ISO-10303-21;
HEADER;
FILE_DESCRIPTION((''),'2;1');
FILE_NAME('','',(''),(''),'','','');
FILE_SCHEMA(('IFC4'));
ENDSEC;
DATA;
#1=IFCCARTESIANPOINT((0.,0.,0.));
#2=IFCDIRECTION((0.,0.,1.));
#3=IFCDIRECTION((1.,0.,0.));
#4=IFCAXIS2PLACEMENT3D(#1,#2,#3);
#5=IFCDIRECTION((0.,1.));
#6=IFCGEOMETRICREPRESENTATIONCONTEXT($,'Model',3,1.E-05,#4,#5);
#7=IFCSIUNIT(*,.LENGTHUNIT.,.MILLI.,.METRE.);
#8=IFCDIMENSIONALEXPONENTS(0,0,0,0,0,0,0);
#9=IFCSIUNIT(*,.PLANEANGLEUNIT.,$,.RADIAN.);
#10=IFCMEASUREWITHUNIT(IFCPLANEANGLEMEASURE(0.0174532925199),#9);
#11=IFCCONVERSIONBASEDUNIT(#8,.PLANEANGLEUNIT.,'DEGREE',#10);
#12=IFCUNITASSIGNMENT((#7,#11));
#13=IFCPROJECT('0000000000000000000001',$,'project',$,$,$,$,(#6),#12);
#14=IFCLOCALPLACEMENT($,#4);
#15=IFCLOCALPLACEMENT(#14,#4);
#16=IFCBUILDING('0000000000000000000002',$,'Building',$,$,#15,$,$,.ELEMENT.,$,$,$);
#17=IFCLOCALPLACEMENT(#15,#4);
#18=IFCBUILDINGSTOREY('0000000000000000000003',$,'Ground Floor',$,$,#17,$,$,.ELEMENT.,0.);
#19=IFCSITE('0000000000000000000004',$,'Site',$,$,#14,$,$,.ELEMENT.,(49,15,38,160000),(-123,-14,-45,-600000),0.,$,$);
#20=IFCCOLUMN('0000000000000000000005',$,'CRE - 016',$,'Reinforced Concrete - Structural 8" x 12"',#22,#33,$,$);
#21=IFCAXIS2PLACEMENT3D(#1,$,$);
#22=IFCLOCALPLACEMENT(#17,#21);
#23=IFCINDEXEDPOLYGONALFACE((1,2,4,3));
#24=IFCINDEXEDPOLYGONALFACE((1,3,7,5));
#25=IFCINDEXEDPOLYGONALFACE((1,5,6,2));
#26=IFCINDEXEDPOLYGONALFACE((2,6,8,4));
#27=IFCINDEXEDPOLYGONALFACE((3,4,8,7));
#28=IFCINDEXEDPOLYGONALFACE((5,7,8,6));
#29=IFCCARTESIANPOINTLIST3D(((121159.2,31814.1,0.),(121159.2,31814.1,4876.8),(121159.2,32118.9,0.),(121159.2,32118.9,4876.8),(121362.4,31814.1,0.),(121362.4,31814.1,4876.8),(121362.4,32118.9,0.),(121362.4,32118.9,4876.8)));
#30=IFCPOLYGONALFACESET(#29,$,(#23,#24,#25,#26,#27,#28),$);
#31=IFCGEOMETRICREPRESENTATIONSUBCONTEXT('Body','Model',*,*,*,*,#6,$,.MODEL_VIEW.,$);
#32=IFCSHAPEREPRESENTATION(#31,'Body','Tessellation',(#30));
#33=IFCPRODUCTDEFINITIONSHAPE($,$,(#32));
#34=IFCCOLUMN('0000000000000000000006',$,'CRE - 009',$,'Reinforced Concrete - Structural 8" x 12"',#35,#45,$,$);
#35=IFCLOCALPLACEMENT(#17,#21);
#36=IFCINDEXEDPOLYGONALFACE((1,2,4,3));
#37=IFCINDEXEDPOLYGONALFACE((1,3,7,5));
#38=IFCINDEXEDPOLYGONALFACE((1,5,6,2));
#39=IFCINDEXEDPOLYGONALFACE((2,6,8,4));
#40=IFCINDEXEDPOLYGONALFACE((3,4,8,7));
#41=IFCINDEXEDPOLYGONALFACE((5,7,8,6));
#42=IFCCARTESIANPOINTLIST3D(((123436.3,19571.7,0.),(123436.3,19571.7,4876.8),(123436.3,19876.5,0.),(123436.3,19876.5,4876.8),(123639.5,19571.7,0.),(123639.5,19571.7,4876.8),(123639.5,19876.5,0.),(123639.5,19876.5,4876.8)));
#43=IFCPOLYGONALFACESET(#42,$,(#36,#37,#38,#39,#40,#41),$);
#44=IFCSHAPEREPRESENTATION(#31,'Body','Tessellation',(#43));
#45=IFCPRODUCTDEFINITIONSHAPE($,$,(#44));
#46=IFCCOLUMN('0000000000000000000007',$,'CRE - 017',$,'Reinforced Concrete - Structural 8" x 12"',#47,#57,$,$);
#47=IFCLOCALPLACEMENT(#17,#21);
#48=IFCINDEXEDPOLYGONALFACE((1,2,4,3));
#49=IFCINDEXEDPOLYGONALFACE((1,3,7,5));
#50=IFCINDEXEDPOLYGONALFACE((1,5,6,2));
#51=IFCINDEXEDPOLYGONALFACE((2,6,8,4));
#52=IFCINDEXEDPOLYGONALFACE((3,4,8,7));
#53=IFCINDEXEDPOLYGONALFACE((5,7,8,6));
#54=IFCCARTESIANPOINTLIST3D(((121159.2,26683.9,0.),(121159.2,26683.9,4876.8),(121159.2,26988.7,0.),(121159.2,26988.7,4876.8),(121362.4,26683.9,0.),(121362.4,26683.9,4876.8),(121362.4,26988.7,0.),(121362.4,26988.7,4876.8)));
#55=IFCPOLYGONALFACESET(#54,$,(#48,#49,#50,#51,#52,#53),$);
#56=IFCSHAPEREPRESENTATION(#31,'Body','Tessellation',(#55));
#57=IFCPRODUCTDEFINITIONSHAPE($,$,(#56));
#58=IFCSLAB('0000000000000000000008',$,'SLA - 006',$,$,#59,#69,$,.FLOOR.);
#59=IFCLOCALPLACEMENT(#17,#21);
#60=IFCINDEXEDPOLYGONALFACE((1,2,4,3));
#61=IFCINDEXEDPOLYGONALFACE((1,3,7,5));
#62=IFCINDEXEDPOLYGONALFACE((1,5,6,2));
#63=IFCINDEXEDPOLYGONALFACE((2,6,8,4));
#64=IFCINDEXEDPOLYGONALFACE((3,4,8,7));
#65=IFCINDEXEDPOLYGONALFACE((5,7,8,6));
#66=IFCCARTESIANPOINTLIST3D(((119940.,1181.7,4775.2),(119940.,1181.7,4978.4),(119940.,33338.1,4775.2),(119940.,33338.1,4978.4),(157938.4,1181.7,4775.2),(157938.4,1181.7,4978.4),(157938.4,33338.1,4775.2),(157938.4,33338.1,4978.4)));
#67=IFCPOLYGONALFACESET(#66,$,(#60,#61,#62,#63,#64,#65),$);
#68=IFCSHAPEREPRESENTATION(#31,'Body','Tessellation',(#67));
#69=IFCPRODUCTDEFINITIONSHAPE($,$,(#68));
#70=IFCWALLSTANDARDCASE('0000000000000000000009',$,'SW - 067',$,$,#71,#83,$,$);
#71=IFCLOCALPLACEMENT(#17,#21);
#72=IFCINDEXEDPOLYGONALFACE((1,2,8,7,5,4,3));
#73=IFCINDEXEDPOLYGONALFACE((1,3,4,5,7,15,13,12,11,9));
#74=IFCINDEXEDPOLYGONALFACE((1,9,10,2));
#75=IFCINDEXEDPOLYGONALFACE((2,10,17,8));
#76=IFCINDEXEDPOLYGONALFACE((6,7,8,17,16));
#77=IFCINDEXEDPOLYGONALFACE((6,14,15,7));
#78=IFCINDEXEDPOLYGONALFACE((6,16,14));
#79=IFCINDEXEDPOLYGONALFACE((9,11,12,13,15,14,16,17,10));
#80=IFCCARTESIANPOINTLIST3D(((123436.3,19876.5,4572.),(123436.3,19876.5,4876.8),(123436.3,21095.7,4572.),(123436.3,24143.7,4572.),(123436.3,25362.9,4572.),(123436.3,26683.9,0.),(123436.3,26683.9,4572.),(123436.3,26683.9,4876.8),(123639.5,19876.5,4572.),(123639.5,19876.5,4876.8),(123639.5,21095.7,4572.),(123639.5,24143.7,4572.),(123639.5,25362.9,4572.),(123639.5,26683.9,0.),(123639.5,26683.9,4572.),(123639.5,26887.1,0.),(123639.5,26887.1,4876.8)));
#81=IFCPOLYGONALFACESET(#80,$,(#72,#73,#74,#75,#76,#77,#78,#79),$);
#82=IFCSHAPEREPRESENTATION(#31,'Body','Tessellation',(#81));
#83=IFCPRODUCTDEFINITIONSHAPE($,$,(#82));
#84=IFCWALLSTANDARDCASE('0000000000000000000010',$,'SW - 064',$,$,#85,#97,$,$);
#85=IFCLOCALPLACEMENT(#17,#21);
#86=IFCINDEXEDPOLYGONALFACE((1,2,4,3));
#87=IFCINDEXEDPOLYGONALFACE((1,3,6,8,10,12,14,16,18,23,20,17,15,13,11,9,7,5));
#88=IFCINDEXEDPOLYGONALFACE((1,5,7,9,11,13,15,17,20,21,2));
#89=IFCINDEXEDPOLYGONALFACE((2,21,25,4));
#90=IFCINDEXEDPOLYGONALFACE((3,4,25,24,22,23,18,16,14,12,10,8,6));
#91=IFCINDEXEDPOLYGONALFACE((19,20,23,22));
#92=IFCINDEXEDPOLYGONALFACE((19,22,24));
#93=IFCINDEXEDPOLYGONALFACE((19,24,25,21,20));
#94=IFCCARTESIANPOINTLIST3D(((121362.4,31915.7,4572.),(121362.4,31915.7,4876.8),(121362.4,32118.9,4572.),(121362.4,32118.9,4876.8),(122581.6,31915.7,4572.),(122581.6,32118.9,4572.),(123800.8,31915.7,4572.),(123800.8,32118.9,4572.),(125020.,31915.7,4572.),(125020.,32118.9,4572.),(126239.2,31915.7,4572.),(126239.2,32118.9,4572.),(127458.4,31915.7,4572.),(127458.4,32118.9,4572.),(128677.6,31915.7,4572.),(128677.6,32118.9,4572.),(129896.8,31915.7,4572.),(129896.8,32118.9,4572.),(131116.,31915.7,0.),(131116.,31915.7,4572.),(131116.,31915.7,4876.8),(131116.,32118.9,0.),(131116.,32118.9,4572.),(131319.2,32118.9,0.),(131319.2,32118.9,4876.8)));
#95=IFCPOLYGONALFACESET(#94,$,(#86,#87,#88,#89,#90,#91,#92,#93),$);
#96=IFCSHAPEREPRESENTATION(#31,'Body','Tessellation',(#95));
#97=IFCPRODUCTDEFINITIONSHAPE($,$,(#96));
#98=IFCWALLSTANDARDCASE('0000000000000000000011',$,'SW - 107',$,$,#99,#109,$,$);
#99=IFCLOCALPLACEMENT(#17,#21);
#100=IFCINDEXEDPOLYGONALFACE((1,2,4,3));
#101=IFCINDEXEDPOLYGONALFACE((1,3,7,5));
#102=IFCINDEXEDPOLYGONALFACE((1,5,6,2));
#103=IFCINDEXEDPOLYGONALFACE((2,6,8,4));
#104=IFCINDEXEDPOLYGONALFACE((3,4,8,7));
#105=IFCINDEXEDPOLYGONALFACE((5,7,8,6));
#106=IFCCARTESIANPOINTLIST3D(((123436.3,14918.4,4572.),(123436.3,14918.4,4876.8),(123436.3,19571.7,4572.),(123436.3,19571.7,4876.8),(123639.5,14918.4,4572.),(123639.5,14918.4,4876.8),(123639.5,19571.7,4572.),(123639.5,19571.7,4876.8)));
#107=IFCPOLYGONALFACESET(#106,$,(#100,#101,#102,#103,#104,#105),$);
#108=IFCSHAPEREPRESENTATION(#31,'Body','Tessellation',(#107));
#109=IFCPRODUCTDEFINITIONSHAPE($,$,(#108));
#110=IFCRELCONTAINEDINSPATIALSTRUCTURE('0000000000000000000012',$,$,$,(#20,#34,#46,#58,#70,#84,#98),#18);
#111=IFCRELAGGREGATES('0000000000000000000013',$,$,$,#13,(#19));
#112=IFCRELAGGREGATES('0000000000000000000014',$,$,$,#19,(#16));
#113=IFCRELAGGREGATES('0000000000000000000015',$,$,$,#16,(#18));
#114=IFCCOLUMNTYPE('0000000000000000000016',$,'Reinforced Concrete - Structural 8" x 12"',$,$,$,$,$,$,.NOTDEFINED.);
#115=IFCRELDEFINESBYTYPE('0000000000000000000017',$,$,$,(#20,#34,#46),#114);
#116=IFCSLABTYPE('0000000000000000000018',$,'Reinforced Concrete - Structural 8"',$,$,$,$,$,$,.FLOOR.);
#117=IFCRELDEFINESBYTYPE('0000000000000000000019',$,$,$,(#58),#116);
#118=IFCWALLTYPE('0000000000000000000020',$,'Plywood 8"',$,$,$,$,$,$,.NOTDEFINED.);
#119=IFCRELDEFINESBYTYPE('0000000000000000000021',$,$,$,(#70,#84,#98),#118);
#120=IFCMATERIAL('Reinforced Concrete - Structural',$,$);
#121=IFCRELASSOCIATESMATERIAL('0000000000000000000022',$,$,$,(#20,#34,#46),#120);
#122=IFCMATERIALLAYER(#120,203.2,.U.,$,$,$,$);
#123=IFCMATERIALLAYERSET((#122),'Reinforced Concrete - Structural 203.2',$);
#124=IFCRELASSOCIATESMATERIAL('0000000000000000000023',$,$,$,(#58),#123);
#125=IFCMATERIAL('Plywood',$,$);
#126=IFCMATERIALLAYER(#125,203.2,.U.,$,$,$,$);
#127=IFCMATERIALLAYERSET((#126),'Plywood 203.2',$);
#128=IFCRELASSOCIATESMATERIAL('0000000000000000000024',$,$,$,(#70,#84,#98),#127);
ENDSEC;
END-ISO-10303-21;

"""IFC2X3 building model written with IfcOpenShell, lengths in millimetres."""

from ifc_helpers import new_model, entity, si_unit, converted_unit, direction, frame, origin_with_axes, origin_2d_with_axis, place, context, subcontext, project, spatial, polyline, rectangle, outline, extrude, material, layer, layer_set, layer_usage, type_object, element, save


model = new_model("IFC2X3")

# Units and contexts
model_context = context("Model", 3, precision=1e-05, world=origin_with_axes(), true_north=direction((0.0, 1.0)))
body_context = subcontext(model_context, "Body", "Model", "MODEL_VIEW")
ifc_project = project(units=[si_unit("LENGTHUNIT", "METRE", prefix="MILLI"), converted_unit("PLANEANGLEUNIT", "DEGREE", entity("IfcPlaneAngleMeasure", 0.0174532925199), si_unit("PLANEANGLEUNIT", "RADIAN"), dimensions=[0, 0, 0, 0, 0, 0, 0])], contexts=[model_context])

# Site, building, storey
site_placement = place(None, origin_with_axes())
site = spatial("IfcSite", under=ifc_project, at=site_placement, Name="Site", CompositionType="ELEMENT", RefLatitude=(49, 15, 38, 160000), RefLongitude=(-123, -14, -45, -600000), RefElevation=0.0)
building_placement = place(site_placement, origin_with_axes())
building = spatial("IfcBuilding", under=site, at=building_placement, Name="Building", CompositionType="ELEMENT")
storey_placement = place(building_placement, origin_with_axes())
storey = spatial("IfcBuildingStorey", under=building, at=storey_placement, Name="Ground Floor", CompositionType="ELEMENT", Elevation=0.0)

# Columns
ifc_material_1 = material(Name="Reinforced Concrete - Structural")
column_type = type_object("IfcColumnType", Name="Reinforced Concrete - Structural 8\" x 12\"", PredefinedType="NOTDEFINED")
for number, where, z_axis, x_axis, name in (
    (1, (121260.8, 31966.5, 0.0), (0.0, 0.0, 1.0), (1.0, 0.0, 0.0), "CRE - 016"),
    (2, (123537.9, 19724.1, 0.0), (0.0, 0.0, 1.0), (1.0, 0.0, 0.0), "CRE - 009"),
    (3, (121260.8, 26836.3, 0.0), (0.0, 0.0, 1.0), (1.0, 0.0, 0.0), "CRE - 017"),
):
    element("IfcColumn", number, at=place(storey_placement, frame(where, z_axis=z_axis, x_axis=x_axis)), inside=storey, type_object=column_type, material=ifc_material_1, Name=name, ObjectType="Reinforced Concrete - Structural 8\" x 12\"", context=body_context, shape_type="SweptSolid", body=[
        extrude(rectangle(XDim=203.2, YDim=304.8, at=origin_2d_with_axis()), origin_with_axes(), (0.0, 0.0, 1.0), 4876.8),
    ])

# Slab
ifc_layer_1 = layer(ifc_material_1, 203.2, ventilated="UNKNOWN")
ifc_layer_set_1 = layer_set([ifc_layer_1], Name="Reinforced Concrete - Structural 203.2")
ifc_layer_usage_1 = layer_usage(ifc_layer_set_1, "AXIS3", "NEGATIVE", 203.2)
slab_type = type_object("IfcSlabType", Name="Reinforced Concrete - Structural 8\"", PredefinedType="FLOOR")
slab_placement = place(storey_placement, frame((119940.0, 33338.1, 4978.4), z_axis=(0.0, 0.0, 1.0), x_axis=(1.0, 0.0, 0.0)))
element("IfcSlab", 4, at=slab_placement, inside=storey, type_object=slab_type, material=ifc_layer_usage_1, Name="SLA - 006", PredefinedType="FLOOR", context=body_context, shape_type="SweptSolid", body=[
    extrude(outline(polyline([(0.0, 0.0), (0.0, -32156.4), (37998.4, -32156.4), (37998.4, 0.0), (0.0, 0.0)])), frame((0.0, 0.0, -203.2), z_axis=(0.0, 0.0, 1.0), x_axis=(1.0, 0.0, 0.0)), (0.0, 0.0, 1.0), 203.2),
])

# Walls, openings
ifc_material_2 = material(Name="Plywood")
ifc_layer_2 = layer(ifc_material_2, 203.2, ventilated="UNKNOWN")
ifc_layer_set_2 = layer_set([ifc_layer_2], Name="Plywood 203.2")
ifc_layer_usage_2 = layer_usage(ifc_layer_set_2, "AXIS2", "NEGATIVE", 0.0)
wall_type = type_object("IfcWallType", Name="Plywood 8\"", PredefinedType="NOTDEFINED")
wall_1_placement = place(storey_placement, frame((123639.5, 26887.1, 0.0), z_axis=(0.0, 0.0, 1.0), x_axis=(0.0, -1.0, 0.0)))
wall_1 = element("IfcWallStandardCase", 5, at=wall_1_placement, inside=storey, type_object=wall_type, material=ifc_layer_usage_2, Name="SW - 067", context=body_context, shape_type="SweptSolid", body=[
    extrude(outline(polyline([(203.2, -203.2), (7010.6, -203.2), (7010.6, 0.0), (0.0, 0.0), (203.2, -203.2)])), origin_with_axes(), (0.0, 0.0, 1.0), 4876.8),
])
opening_1_placement = place(wall_1_placement, frame((6451.8, 0.0, 0.0), z_axis=(0.0, 0.0, 1.0), x_axis=(1.0, 0.0, 0.0)))
element("IfcOpeningElement", 6, at=opening_1_placement, cuts=wall_1, context=body_context, shape_type="SweptSolid", body=[
    extrude(rectangle(XDim=1320.8, YDim=4572.0, at=origin_2d_with_axis()), frame((0.0, 203.2, 2286.0), z_axis=(0.0, -1.0, 0.0), x_axis=(-1.0, 0.0, 0.0)), (0.0, 0.0, 1.0), 609.6),
])
opening_2_placement = place(wall_1_placement, frame((863.7, 0.0, 0.0), z_axis=(0.0, 0.0, 1.0), x_axis=(1.0, 0.0, 0.0)))
element("IfcOpeningElement", 7, at=opening_2_placement, cuts=wall_1, context=body_context, shape_type="SweptSolid", body=[
    extrude(rectangle(XDim=1321.0, YDim=4572.0, at=origin_2d_with_axis()), frame((0.0, 203.2, 2286.0), z_axis=(0.0, -1.0, 0.0), x_axis=(-1.0, 0.0, 0.0)), (0.0, 0.0, 1.0), 609.6),
])
opening_3_placement = place(wall_1_placement, frame((2133.8, 0.0, 0.0), z_axis=(0.0, 0.0, 1.0), x_axis=(1.0, 0.0, 0.0)))
element("IfcOpeningElement", 8, at=opening_3_placement, cuts=wall_1, context=body_context, shape_type="SweptSolid", body=[
    extrude(rectangle(XDim=1219.2, YDim=4572.0, at=origin_2d_with_axis()), frame((0.0, 203.2, 2286.0), z_axis=(0.0, -1.0, 0.0), x_axis=(-1.0, 0.0, 0.0)), (0.0, 0.0, 1.0), 609.6),
])
opening_4_placement = place(wall_1_placement, frame((4267.4, 0.0, 0.0), z_axis=(0.0, 0.0, 1.0), x_axis=(1.0, 0.0, 0.0)))
element("IfcOpeningElement", 9, at=opening_4_placement, cuts=wall_1, context=body_context, shape_type="SweptSolid", body=[
    extrude(rectangle(XDim=3048.0, YDim=4572.0, at=origin_2d_with_axis()), frame((0.0, 203.2, 2286.0), z_axis=(0.0, -1.0, 0.0), x_axis=(-1.0, 0.0, 0.0)), (0.0, 0.0, 1.0), 609.6),
])
ifc_layer_usage_3 = layer_usage(ifc_layer_set_2, "AXIS2", "POSITIVE", 0.0)
wall_2_placement = place(storey_placement, frame((121362.4, 31915.7, 0.0), z_axis=(0.0, 0.0, 1.0), x_axis=(1.0, 0.0, 0.0)))
wall_2 = element("IfcWallStandardCase", 10, at=wall_2_placement, inside=storey, type_object=wall_type, material=ifc_layer_usage_3, Name="SW - 064", context=body_context, shape_type="SweptSolid", body=[
    extrude(outline(polyline([(0.0, 0.0), (9753.6, 0.0), (9956.8, 203.2), (0.0, 203.2), (0.0, 0.0)])), origin_with_axes(), (0.0, 0.0, 1.0), 4876.8),
])
opening_5_placement = place(wall_2_placement, frame((9144.0, 0.0, 0.0), z_axis=(0.0, 0.0, 1.0), x_axis=(1.0, 0.0, 0.0)))
element("IfcOpeningElement", 11, at=opening_5_placement, cuts=wall_2, context=body_context, shape_type="SweptSolid", body=[
    extrude(rectangle(XDim=1219.2, YDim=4572.0, at=origin_2d_with_axis()), frame((0.0, -203.2, 2286.0), z_axis=(0.0, 1.0, 0.0), x_axis=(1.0, 0.0, 0.0)), (0.0, 0.0, 1.0), 609.6),
])
opening_6_placement = place(wall_2_placement, frame((7924.8, 0.0, 0.0), z_axis=(0.0, 0.0, 1.0), x_axis=(1.0, 0.0, 0.0)))
element("IfcOpeningElement", 12, at=opening_6_placement, cuts=wall_2, context=body_context, shape_type="SweptSolid", body=[
    extrude(rectangle(XDim=1219.2, YDim=4572.0, at=origin_2d_with_axis()), frame((0.0, -203.2, 2286.0), z_axis=(0.0, -1.0, 0.0), x_axis=(-1.0, 0.0, 0.0)), (0.0, 0.0, -1.0), 609.6),
])
opening_7_placement = place(wall_2_placement, frame((6705.6, 0.0, 0.0), z_axis=(0.0, 0.0, 1.0), x_axis=(1.0, 0.0, 0.0)))
element("IfcOpeningElement", 13, at=opening_7_placement, cuts=wall_2, context=body_context, shape_type="SweptSolid", body=[
    extrude(rectangle(XDim=1219.2, YDim=4572.0, at=origin_2d_with_axis()), frame((0.0, -203.2, 2286.0), z_axis=(0.0, -1.0, 0.0), x_axis=(-1.0, 0.0, 0.0)), (0.0, 0.0, -1.0), 609.6),
])
opening_8_placement = place(wall_2_placement, frame((5486.4, 0.0, 0.0), z_axis=(0.0, 0.0, 1.0), x_axis=(1.0, 0.0, 0.0)))
element("IfcOpeningElement", 14, at=opening_8_placement, cuts=wall_2, context=body_context, shape_type="SweptSolid", body=[
    extrude(rectangle(XDim=1219.2, YDim=4572.0, at=origin_2d_with_axis()), frame((0.0, -203.2, 2286.0), z_axis=(0.0, 1.0, 0.0), x_axis=(1.0, 0.0, 0.0)), (0.0, 0.0, 1.0), 609.6),
])
opening_9_placement = place(wall_2_placement, frame((4267.2, 0.0, 0.0), z_axis=(0.0, 0.0, 1.0), x_axis=(1.0, 0.0, 0.0)))
element("IfcOpeningElement", 15, at=opening_9_placement, cuts=wall_2, context=body_context, shape_type="SweptSolid", body=[
    extrude(rectangle(XDim=1219.2, YDim=4572.0, at=origin_2d_with_axis()), frame((0.0, -203.2, 2286.0), z_axis=(0.0, -1.0, 0.0), x_axis=(-1.0, 0.0, 0.0)), (0.0, 0.0, -1.0), 609.6),
])
opening_10_placement = place(wall_2_placement, frame((3048.0, 0.0, 0.0), z_axis=(0.0, 0.0, 1.0), x_axis=(1.0, 0.0, 0.0)))
element("IfcOpeningElement", 16, at=opening_10_placement, cuts=wall_2, context=body_context, shape_type="SweptSolid", body=[
    extrude(rectangle(XDim=1219.2, YDim=4572.0, at=origin_2d_with_axis()), frame((0.0, -203.2, 2286.0), z_axis=(0.0, -1.0, 0.0), x_axis=(-1.0, 0.0, 0.0)), (0.0, 0.0, -1.0), 609.6),
])
opening_11_placement = place(wall_2_placement, frame((1828.8, 0.0, 0.0), z_axis=(0.0, 0.0, 1.0), x_axis=(1.0, 0.0, 0.0)))
element("IfcOpeningElement", 17, at=opening_11_placement, cuts=wall_2, context=body_context, shape_type="SweptSolid", body=[
    extrude(rectangle(XDim=1219.2, YDim=4572.0, at=origin_2d_with_axis()), frame((0.0, -203.2, 2286.0), z_axis=(0.0, -1.0, 0.0), x_axis=(-1.0, 0.0, 0.0)), (0.0, 0.0, -1.0), 609.6),
])
opening_12_placement = place(wall_2_placement, frame((609.6, 0.0, 0.0), z_axis=(0.0, 0.0, 1.0), x_axis=(1.0, 0.0, 0.0)))
element("IfcOpeningElement", 18, at=opening_12_placement, cuts=wall_2, context=body_context, shape_type="SweptSolid", body=[
    extrude(rectangle(XDim=1219.2, YDim=4572.0, at=origin_2d_with_axis()), frame((0.0, -203.2, 2286.0), z_axis=(0.0, 1.0, 0.0), x_axis=(1.0, 0.0, 0.0)), (0.0, 0.0, 1.0), 609.6),
])

# Wall, opening
ifc_layer_usage_4 = layer_usage(ifc_layer_set_2, "AXIS2", "NEGATIVE", 0.0)
wall_3_placement = place(storey_placement, frame((123639.5, 19571.7, 0.0), z_axis=(0.0, 0.0, 1.0), x_axis=(0.0, -1.0, 0.0)))
wall_3 = element("IfcWallStandardCase", 19, at=wall_3_placement, inside=storey, type_object=wall_type, material=ifc_layer_usage_4, Name="SW - 107", context=body_context, shape_type="SweptSolid", body=[
    extrude(outline(polyline([(0.0, -203.2), (4653.2, -203.2), (4653.2, 0.0), (0.0, 0.0), (0.0, -203.2)])), origin_with_axes(), (0.0, 0.0, 1.0), 4876.8),
])
opening_13_placement = place(wall_3_placement, frame((2326.6, 0.0, 0.0), z_axis=(0.0, 0.0, 1.0), x_axis=(1.0, 0.0, 0.0)))
element("IfcOpeningElement", 20, at=opening_13_placement, cuts=wall_3, context=body_context, shape_type="SweptSolid", body=[
    extrude(rectangle(XDim=4653.2, YDim=4572.0, at=origin_2d_with_axis()), frame((0.0, 203.2, 2286.0), z_axis=(0.0, -1.0, 0.0), x_axis=(-1.0, 0.0, 0.0)), (0.0, 0.0, 1.0), 609.6),
])

save(model, "model.ifc")
